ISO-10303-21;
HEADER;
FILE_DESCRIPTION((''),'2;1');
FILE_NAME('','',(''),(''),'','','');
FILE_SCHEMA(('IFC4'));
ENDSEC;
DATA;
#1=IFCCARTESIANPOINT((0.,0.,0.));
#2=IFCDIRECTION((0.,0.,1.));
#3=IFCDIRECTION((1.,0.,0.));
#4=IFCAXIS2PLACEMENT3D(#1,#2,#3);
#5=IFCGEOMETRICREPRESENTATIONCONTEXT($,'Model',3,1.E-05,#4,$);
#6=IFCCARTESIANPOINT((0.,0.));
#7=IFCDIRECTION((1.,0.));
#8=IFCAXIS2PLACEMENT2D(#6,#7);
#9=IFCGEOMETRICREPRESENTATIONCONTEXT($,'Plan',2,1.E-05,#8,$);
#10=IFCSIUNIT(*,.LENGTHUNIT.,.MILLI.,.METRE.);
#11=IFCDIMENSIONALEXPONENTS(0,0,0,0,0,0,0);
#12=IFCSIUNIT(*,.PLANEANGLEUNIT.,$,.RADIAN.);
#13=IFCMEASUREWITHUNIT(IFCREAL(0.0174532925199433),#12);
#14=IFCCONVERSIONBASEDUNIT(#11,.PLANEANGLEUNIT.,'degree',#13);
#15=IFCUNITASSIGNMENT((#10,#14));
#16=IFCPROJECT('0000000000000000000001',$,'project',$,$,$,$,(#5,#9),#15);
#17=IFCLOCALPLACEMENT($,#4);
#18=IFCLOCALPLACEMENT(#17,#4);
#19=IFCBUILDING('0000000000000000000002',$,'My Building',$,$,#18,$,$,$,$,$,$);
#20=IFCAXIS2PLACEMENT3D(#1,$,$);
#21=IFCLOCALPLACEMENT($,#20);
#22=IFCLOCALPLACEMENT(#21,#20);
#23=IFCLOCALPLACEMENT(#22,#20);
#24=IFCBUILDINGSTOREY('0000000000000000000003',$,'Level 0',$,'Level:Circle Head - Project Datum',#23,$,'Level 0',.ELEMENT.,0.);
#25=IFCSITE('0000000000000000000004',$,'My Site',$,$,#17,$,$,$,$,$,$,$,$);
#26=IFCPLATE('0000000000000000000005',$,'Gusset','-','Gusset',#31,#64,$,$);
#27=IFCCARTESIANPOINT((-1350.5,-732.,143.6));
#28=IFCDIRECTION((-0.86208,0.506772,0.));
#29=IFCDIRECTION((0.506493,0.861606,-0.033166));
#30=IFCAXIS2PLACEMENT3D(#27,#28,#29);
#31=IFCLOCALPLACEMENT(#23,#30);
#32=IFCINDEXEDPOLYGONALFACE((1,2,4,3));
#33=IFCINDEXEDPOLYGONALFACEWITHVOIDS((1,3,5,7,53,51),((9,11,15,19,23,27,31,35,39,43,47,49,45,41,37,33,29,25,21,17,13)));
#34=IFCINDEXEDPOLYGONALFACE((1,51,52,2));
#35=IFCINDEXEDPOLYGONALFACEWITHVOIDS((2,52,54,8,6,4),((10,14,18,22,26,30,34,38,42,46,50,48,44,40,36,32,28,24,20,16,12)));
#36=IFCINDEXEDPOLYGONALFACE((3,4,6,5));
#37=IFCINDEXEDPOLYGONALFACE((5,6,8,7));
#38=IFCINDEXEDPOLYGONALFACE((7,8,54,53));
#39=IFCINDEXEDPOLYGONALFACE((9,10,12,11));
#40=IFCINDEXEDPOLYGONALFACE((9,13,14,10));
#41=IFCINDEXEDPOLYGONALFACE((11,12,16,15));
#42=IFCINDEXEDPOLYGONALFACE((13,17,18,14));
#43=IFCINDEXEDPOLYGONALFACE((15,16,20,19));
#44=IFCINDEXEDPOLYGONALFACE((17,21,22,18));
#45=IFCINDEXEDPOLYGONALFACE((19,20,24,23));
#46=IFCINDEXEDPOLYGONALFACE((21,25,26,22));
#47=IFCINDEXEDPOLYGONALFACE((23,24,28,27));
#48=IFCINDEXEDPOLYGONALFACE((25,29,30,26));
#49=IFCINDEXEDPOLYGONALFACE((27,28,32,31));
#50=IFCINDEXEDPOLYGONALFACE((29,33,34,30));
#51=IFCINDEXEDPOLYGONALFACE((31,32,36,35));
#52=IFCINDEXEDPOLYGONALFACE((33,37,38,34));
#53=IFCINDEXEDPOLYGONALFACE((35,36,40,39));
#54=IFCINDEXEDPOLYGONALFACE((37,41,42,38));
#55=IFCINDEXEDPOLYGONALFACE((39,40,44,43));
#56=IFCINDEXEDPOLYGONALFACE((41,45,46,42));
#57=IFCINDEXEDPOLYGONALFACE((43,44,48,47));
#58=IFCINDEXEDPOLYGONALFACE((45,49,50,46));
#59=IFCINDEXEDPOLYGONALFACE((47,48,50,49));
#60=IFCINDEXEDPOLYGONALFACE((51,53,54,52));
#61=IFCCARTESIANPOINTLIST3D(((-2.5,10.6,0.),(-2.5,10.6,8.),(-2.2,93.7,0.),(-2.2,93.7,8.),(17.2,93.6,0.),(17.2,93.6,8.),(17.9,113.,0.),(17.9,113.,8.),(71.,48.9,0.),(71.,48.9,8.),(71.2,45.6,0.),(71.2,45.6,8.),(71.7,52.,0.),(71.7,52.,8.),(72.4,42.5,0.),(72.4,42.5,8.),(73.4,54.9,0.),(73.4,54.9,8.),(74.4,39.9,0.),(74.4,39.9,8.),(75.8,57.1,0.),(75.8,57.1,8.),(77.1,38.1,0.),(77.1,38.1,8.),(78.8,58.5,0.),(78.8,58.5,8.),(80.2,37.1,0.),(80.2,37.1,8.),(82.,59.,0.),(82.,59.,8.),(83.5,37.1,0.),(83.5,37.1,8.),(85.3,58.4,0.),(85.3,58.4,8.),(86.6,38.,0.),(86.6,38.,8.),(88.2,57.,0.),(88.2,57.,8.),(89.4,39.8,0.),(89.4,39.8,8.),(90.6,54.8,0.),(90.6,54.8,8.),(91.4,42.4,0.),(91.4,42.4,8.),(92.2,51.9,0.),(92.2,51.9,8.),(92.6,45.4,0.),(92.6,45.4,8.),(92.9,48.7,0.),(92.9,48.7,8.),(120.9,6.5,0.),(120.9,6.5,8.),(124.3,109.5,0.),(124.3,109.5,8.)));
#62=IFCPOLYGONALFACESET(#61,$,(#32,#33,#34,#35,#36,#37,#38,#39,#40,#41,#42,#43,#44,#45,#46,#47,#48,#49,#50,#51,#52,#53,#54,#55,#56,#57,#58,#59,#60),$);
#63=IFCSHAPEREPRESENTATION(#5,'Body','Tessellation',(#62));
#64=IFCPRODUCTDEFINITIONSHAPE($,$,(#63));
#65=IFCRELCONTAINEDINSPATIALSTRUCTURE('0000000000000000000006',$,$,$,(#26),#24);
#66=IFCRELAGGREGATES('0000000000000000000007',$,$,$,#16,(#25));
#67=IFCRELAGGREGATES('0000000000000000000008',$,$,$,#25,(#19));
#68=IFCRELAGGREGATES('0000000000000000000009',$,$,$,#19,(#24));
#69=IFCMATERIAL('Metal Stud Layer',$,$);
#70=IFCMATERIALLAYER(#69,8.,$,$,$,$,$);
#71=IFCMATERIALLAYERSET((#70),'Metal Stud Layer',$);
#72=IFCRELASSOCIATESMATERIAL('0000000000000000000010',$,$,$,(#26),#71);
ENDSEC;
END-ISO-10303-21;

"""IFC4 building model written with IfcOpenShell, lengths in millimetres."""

from ifc_helpers import new_model, entity, si_unit, converted_unit, point, frame, frame_2d, origin, origin_with_axes, origin_2d_with_axis, place, context, project, spatial, polyline, circle_curve, line_curve, trimmed, segment, composite_curve, circle, outline, extrude, material, layer, layer_set, element, save


model = new_model("IFC4")

# Units and contexts
model_context = context("Model", 3, precision=1e-05, world=origin_with_axes())
plan_context = context("Plan", 2, precision=1e-05, world=origin_2d_with_axis())
ifc_project = project(units=[si_unit("LENGTHUNIT", "METRE", prefix="MILLI"), converted_unit("PLANEANGLEUNIT", "degree", entity("IfcReal", 0.0174532925199433), si_unit("PLANEANGLEUNIT", "RADIAN"), dimensions=[0, 0, 0, 0, 0, 0, 0])], contexts=[model_context, plan_context])

# Site, building, storey
site_placement = place(None, origin_with_axes())
site = spatial("IfcSite", under=ifc_project, at=site_placement, Name="My Site")
building_placement = place(site_placement, origin_with_axes())
building = spatial("IfcBuilding", under=site, at=building_placement, Name="My Building")
placement_1 = place(None, origin())
placement_2 = place(placement_1, origin())
storey_placement = place(placement_2, origin())
storey = spatial("IfcBuildingStorey", under=building, at=storey_placement, Name="Level 0", ObjectType="Level:Circle Head - Project Datum", LongName="Level 0", CompositionType="ELEMENT", Elevation=0.0)

# Plate, openings
ifc_material_1 = material(Name="Metal Stud Layer")
ifc_layer_1 = layer(ifc_material_1, 8.0)
ifc_layer_set_1 = layer_set([ifc_layer_1], Name="Metal Stud Layer")
plate_1_placement = place(storey_placement, frame((-1350.5, -732.0, 143.6), z_axis=(-0.86208, 0.506772, 0.0), x_axis=(0.506493, 0.861606, -0.033166)))
plate_1 = element("IfcPlate", 1, at=plate_1_placement, inside=storey, material=ifc_layer_set_1, Name="Gusset", Description="-", ObjectType="Gusset", context=model_context, shape_type="SweptSolid", body=[
    extrude(outline(polyline([(120.9, 6.5), (124.3, 109.5), (17.9, 113.0), (17.2, 93.6), (-2.2, 93.7), (-2.5, 10.6), (120.9, 6.5)])), origin_with_axes(), (0.0, 0.0, 1.0), 8.0),
])
opening_1_placement = place(plate_1_placement, frame((81.9, 48.0, 8.5), z_axis=(0.0, 0.0, -1.0), x_axis=(0.862509, -0.506042, 0.0)))
element("IfcOpeningElement", 2, at=opening_1_placement, cuts=plate_1, ObjectType="Opening", context=model_context, shape_type="SweptSolid", body=[
    extrude(circle(Radius=11.0, at=origin_2d_with_axis()), origin(), (0.0, 0.0, 1.0), 9.0),
])
opening_2_placement = place(plate_1_placement, origin_with_axes())
element("IfcOpeningElement", 3, at=opening_2_placement, cuts=plate_1, ObjectType="Opening", context=model_context, shape_type="SweptSolid", body=[
    extrude(outline(composite_curve([segment(trimmed(line_curve((17.2, 93.6), (-0.999992, 0.004054), 19.425957), [point((17.2, 93.6))], [point((-2.2, 93.7))], True, "CARTESIAN"), True, "CONTINUOUS"), segment(trimmed(circle_curve(frame_2d((-2.1, 113.7), x_axis=(1.0, 0.0)), 20.0), [point((-2.2, 93.7))], [point((17.9, 113.0))], True, "CARTESIAN"), True, "CONTINUOUS"), segment(trimmed(line_curve((17.9, 113.0), (-0.033166, -0.99945), 19.425957), [point((17.9, 113.0))], [point((17.2, 93.6))], True, "CARTESIAN"), True, "CONTINUOUS")], self_intersect=False)), origin(), (0.0, 0.0, 1.0), 8.0),
])

save(model, "model.ifc")
